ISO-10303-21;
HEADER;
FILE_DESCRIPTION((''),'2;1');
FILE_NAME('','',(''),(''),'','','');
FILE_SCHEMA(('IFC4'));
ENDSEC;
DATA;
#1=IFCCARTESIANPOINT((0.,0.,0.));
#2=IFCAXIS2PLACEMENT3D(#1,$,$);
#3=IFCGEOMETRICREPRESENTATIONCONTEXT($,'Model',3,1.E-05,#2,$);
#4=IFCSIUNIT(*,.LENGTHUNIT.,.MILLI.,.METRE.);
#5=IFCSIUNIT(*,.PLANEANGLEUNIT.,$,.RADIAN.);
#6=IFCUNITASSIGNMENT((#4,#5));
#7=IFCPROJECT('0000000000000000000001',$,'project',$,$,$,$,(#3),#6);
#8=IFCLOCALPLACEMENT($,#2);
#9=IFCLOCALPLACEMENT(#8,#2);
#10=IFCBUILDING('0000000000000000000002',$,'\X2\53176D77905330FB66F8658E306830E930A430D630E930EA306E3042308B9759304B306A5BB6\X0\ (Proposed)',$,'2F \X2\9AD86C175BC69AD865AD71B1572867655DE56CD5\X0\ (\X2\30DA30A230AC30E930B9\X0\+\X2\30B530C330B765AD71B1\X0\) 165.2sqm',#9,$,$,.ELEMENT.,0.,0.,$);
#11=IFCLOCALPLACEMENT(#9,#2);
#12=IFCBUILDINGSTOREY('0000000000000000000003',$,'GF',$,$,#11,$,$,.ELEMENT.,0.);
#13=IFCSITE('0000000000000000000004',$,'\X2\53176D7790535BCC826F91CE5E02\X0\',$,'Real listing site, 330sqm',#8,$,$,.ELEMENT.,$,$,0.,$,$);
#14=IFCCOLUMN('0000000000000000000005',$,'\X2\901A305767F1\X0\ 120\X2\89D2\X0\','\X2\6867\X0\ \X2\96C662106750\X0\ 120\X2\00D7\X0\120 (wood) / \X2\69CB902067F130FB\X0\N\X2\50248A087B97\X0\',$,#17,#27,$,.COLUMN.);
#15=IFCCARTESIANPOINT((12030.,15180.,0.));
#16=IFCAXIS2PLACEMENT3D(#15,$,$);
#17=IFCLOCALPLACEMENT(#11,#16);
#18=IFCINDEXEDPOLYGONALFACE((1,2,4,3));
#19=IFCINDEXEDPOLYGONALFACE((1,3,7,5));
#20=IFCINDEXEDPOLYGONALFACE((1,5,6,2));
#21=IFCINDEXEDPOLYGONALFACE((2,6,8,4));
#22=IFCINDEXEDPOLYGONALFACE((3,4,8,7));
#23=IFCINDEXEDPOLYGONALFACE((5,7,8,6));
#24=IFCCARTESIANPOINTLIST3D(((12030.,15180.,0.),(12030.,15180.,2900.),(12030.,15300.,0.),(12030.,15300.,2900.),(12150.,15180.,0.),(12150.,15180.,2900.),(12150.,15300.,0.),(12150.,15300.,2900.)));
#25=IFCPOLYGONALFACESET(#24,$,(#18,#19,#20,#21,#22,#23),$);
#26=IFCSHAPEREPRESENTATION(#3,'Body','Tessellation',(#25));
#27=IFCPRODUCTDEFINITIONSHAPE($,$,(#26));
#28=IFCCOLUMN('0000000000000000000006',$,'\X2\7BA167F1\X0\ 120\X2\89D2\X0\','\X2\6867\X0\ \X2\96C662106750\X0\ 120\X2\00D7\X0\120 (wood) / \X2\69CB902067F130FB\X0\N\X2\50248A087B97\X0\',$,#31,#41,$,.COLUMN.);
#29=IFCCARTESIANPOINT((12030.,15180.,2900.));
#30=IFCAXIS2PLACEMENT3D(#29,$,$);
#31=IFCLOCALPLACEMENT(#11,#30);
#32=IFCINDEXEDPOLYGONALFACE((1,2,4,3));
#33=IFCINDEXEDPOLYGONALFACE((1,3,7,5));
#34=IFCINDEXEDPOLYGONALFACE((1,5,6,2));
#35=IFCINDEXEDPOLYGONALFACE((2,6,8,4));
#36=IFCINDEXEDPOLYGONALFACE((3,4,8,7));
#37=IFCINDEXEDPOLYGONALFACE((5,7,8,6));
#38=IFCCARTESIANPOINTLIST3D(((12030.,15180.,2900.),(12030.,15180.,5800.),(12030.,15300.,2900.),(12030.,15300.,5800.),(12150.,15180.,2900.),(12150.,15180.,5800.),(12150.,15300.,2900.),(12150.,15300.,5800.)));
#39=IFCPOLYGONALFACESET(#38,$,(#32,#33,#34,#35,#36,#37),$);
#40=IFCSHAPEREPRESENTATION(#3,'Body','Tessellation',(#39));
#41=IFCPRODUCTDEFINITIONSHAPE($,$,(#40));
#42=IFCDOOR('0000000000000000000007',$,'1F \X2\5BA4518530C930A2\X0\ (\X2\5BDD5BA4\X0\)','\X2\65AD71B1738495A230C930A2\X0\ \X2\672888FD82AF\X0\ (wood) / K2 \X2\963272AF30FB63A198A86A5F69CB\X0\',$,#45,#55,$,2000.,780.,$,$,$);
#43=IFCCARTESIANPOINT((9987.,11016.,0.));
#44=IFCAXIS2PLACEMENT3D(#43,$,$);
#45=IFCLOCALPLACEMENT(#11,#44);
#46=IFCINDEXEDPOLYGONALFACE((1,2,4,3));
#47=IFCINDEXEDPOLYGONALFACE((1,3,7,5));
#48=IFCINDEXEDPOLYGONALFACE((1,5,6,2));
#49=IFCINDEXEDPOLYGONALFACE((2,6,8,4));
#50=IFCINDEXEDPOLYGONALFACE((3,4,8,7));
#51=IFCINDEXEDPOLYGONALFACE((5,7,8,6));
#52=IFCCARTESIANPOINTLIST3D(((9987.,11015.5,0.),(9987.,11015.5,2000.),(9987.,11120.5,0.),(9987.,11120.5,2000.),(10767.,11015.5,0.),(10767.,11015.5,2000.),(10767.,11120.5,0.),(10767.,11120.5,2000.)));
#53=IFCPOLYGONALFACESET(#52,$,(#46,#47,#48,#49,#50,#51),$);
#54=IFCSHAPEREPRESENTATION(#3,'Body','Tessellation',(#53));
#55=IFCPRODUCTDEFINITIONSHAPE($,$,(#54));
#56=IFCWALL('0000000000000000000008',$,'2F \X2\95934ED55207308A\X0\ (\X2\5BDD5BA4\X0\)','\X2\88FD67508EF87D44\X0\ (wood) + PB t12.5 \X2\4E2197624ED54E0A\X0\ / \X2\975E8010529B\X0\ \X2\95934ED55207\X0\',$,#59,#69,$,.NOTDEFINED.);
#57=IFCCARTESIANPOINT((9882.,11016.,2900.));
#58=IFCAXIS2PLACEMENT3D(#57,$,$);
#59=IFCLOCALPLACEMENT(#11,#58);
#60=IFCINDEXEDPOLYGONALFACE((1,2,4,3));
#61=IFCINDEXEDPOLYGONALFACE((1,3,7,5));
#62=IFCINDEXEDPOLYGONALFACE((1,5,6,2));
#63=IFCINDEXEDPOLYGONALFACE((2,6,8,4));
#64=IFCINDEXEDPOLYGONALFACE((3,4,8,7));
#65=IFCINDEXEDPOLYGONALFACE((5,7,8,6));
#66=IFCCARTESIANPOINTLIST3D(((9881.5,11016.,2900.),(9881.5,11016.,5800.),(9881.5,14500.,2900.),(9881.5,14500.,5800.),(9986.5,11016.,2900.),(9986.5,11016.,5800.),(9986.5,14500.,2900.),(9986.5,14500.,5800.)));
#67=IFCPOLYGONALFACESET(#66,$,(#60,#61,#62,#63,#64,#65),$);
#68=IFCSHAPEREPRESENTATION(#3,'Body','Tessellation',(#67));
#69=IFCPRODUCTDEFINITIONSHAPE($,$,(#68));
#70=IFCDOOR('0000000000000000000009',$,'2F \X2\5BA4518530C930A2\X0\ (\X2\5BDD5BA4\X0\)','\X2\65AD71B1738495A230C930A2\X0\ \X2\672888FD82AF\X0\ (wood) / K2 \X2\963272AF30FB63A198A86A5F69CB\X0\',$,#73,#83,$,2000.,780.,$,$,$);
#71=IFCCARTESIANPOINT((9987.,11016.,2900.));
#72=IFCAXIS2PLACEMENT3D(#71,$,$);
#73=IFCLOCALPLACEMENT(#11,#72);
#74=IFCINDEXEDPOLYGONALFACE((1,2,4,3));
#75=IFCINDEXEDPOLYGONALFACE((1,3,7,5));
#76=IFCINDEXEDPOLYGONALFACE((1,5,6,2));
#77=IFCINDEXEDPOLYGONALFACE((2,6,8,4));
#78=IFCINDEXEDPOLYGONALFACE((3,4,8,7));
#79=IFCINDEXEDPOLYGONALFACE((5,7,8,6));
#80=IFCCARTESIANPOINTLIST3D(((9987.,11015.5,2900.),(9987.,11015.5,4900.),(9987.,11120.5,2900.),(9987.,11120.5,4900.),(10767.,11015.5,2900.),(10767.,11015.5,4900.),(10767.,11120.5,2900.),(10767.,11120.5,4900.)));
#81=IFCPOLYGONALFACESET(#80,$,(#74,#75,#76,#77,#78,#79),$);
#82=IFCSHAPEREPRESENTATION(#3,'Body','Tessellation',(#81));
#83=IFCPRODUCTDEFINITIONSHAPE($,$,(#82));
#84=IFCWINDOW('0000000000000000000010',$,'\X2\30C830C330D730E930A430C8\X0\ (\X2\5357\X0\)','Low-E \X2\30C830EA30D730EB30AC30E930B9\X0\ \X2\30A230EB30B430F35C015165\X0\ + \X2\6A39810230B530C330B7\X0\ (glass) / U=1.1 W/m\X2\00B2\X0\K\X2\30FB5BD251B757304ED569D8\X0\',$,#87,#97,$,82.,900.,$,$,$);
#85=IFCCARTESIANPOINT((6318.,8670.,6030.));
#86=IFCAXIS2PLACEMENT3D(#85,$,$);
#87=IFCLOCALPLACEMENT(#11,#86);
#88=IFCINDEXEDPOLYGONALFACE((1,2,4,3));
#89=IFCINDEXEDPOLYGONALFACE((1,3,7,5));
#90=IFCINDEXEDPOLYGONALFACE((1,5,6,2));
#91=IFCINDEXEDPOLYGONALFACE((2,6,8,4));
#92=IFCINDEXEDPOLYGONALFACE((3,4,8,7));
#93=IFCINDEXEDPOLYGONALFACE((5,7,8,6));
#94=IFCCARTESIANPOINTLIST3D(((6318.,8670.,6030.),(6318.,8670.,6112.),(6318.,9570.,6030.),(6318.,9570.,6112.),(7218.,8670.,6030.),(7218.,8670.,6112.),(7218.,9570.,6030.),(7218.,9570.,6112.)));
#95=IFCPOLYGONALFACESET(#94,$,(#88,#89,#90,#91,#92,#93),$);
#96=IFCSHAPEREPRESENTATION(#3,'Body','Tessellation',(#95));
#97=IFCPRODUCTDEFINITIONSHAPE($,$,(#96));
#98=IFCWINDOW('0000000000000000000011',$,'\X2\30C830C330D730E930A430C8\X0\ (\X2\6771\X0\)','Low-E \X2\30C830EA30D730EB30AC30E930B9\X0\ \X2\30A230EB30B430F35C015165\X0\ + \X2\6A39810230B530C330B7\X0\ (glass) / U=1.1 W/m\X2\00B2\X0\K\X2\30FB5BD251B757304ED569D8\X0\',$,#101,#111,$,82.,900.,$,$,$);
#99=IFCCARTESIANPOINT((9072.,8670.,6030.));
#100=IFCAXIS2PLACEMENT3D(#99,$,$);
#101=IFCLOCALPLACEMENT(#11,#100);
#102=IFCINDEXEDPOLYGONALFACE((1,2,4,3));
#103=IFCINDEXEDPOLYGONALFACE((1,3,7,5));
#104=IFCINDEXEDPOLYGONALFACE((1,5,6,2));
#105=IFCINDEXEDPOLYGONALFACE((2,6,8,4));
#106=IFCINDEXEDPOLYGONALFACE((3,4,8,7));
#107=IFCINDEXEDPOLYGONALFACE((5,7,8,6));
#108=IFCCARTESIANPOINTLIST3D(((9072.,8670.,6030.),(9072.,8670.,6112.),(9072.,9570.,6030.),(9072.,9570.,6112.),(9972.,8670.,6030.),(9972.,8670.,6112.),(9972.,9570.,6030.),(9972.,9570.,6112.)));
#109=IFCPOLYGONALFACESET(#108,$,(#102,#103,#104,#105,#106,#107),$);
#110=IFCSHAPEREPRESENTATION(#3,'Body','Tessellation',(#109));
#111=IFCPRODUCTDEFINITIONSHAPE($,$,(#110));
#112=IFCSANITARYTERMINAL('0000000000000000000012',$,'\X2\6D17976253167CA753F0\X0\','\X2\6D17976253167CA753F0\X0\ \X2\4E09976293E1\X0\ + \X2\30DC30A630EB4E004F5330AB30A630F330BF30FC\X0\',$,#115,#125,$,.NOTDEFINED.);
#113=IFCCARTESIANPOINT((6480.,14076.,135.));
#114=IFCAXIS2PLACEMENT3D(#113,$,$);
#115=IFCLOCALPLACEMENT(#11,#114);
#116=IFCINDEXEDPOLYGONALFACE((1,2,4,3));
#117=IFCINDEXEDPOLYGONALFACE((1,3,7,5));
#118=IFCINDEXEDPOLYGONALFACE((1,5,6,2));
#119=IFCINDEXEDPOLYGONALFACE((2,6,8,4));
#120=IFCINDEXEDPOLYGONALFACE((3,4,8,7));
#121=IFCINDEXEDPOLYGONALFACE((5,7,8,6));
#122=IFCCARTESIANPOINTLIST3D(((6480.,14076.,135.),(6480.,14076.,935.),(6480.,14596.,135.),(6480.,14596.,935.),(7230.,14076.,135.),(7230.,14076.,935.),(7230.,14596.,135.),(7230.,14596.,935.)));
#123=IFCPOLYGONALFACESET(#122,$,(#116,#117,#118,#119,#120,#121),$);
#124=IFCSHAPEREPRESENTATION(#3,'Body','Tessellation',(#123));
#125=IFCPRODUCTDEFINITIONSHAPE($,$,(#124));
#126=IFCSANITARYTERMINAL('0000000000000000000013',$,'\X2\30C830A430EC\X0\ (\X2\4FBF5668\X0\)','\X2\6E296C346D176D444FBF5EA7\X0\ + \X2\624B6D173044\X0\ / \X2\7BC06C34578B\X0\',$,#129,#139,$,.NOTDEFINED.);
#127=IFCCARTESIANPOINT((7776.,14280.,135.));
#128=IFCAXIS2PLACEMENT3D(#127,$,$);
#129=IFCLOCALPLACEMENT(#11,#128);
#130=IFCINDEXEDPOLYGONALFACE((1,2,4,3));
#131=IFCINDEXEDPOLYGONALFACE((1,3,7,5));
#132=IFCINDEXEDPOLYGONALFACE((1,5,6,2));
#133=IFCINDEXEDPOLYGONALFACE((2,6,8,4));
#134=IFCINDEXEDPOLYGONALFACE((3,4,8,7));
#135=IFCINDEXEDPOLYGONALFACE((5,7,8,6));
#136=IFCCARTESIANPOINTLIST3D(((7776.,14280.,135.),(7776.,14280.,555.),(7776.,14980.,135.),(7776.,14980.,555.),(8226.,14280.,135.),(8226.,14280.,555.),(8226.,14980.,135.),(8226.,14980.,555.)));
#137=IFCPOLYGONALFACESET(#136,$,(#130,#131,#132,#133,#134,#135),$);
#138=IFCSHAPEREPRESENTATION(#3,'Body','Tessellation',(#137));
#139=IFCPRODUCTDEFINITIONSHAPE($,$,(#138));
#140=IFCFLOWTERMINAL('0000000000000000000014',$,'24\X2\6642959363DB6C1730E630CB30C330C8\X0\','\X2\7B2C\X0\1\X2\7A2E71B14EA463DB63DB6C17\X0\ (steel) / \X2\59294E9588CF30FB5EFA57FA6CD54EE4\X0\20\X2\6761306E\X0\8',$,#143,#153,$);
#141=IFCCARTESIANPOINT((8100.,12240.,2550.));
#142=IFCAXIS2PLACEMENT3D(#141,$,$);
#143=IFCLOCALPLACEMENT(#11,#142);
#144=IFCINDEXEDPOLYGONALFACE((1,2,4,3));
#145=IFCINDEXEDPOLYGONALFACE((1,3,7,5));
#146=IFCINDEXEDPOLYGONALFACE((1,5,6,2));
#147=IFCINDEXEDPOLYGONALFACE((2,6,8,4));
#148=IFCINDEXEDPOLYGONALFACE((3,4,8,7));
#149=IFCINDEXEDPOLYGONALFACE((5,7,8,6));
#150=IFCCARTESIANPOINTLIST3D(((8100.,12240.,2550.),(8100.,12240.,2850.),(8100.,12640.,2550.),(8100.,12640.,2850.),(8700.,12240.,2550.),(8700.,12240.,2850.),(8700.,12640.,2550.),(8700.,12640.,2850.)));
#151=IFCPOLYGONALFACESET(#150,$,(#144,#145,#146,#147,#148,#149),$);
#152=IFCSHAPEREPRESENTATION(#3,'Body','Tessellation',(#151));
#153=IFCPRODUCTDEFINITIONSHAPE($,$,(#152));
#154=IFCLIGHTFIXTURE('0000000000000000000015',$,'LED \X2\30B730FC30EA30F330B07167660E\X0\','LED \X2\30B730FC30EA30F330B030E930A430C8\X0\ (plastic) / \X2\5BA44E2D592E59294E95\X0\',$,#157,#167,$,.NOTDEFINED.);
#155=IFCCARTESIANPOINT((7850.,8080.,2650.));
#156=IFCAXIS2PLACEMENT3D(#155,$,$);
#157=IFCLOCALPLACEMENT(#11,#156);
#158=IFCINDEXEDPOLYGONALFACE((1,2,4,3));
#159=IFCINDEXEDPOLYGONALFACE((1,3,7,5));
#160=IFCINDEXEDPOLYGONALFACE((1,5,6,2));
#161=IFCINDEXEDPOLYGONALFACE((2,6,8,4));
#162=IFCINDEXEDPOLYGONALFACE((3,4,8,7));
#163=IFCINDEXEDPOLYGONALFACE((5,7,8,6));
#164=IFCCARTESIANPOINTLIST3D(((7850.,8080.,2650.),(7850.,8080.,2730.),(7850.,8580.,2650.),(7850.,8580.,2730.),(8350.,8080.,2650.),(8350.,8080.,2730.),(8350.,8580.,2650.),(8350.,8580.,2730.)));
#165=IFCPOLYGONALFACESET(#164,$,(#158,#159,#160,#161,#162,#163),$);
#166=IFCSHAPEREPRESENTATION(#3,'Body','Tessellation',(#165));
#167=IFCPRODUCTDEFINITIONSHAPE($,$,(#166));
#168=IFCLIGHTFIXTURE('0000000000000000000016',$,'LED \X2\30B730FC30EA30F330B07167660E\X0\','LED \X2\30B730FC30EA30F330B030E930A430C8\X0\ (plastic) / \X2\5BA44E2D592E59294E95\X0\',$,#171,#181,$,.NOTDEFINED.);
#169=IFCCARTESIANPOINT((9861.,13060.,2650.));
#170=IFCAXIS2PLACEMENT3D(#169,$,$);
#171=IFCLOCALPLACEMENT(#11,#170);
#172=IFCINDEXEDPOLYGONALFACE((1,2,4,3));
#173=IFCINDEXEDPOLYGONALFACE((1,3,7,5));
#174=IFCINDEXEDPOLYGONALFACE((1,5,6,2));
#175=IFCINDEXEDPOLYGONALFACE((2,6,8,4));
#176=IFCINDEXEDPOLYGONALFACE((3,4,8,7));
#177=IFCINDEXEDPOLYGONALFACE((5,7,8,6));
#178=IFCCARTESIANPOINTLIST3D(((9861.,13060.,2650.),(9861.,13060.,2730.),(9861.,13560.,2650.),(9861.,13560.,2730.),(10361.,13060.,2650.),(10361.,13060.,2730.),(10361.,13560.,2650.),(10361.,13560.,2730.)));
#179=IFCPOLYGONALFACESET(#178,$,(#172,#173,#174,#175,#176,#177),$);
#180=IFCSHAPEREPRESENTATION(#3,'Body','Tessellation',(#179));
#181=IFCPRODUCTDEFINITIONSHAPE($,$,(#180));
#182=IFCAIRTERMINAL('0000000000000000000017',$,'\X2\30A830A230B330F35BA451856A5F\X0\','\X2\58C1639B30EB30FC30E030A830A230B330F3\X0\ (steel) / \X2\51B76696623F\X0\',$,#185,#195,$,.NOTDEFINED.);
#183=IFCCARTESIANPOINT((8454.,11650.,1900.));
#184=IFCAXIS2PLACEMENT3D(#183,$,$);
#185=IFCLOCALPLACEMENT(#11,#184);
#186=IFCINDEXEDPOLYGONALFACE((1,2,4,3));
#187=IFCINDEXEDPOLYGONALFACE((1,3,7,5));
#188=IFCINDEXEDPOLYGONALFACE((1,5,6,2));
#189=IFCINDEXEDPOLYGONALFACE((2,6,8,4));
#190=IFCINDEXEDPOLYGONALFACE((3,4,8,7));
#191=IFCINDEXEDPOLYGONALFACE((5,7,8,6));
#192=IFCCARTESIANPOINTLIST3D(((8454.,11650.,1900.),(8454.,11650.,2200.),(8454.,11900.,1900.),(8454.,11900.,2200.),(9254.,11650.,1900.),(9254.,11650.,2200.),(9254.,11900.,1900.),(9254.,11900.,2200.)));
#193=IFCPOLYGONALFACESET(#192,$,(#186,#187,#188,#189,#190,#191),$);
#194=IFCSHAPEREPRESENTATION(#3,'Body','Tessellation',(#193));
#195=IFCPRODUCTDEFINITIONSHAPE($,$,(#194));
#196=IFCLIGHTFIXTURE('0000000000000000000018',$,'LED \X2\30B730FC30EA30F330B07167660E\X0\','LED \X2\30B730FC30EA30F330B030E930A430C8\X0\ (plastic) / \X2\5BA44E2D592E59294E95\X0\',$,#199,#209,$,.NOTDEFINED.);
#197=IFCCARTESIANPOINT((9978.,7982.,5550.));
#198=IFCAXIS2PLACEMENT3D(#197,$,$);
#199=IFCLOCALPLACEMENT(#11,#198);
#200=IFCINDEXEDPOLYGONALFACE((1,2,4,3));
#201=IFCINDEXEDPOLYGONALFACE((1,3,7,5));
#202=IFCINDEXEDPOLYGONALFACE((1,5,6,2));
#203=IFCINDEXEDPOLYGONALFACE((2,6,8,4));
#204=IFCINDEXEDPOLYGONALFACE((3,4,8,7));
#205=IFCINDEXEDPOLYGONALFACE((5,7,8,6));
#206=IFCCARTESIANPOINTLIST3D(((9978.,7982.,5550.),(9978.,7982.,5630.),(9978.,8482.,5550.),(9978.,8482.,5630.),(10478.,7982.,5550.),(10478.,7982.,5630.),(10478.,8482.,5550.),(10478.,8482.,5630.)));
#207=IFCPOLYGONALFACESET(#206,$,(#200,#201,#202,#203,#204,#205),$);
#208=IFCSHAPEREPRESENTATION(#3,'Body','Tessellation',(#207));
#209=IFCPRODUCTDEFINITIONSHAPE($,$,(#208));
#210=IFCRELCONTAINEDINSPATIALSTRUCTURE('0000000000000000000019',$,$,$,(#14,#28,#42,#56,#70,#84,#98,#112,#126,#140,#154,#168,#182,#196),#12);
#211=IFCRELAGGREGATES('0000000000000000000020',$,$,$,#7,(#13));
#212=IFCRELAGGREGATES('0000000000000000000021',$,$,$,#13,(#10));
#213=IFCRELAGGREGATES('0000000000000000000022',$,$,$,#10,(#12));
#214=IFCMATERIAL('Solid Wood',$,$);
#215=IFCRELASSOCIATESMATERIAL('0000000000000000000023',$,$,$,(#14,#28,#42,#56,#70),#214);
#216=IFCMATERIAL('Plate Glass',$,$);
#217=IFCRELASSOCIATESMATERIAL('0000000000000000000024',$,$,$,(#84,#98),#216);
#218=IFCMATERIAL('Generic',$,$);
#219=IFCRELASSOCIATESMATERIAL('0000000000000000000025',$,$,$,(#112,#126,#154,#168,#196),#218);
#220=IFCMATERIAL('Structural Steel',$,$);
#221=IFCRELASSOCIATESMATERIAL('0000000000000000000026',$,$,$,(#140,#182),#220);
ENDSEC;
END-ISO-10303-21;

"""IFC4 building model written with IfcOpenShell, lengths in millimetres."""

from ifc_helpers import new_model, si_unit, frame, frame_2d, origin, place, context, project, spatial, rectangle, extrude, material, element, save


model = new_model("IFC4")

# Units and contexts
model_context = context("Model", 3, precision=1e-05, world=origin())
ifc_project = project(units=[si_unit("LENGTHUNIT", "METRE", prefix="MILLI"), si_unit("PLANEANGLEUNIT", "RADIAN")], contexts=[model_context])

# Site, building, storey
site_placement = place(None, origin())
site = spatial("IfcSite", under=ifc_project, at=site_placement, Name="北海道富良野市", ObjectType="Real listing site, 330sqm", CompositionType="ELEMENT", RefElevation=0.0)
building_placement = place(site_placement, origin())
building = spatial("IfcBuilding", under=site, at=building_placement, Name="北海道・書斎とライブラリのある静かな家 (Proposed)", ObjectType="2F 高気密高断熱在来工法 (ペアガラス+サッシ断熱) 165.2sqm", CompositionType="ELEMENT", ElevationOfRefHeight=0.0, ElevationOfTerrain=0.0)
storey_placement = place(building_placement, origin())
storey = spatial("IfcBuildingStorey", under=building, at=storey_placement, Name="GF", CompositionType="ELEMENT", Elevation=0.0)

# Columns
ifc_material_1 = material(Name="Solid Wood")
column_1_placement = place(storey_placement, frame((12030.0, 15180.0, 0.0)))
element("IfcColumn", 1, at=column_1_placement, inside=storey, material=ifc_material_1, Name="通し柱 120角", Description="桧 集成材 120×120 (wood) / 構造柱・N値計算", PredefinedType="COLUMN", context=model_context, shape_type="SweptSolid", body=[
    extrude(rectangle(XDim=120.0, YDim=120.0, at=frame_2d((60.0, 60.0))), frame((12030.0, 15180.0, 0.0)), (0.0, 0.0, 1.0), 2900.0),
])
column_2_placement = place(storey_placement, frame((12030.0, 15180.0, 2900.0)))
element("IfcColumn", 2, at=column_2_placement, inside=storey, material=ifc_material_1, Name="管柱 120角", Description="桧 集成材 120×120 (wood) / 構造柱・N値計算", PredefinedType="COLUMN", context=model_context, shape_type="SweptSolid", body=[
    extrude(rectangle(XDim=120.0, YDim=120.0, at=frame_2d((60.0, 60.0))), frame((12030.0, 15180.0, 2900.0)), (0.0, 0.0, 1.0), 2900.0),
])

# Door
door_1_placement = place(storey_placement, frame((9987.0, 11016.0, 0.0)))
element("IfcDoor", 3, at=door_1_placement, inside=storey, material=ifc_material_1, Name="1F 室内ドア (寝室)", Description="断熱玄関ドア 木製芯 (wood) / K2 防犯・採風機構", OverallHeight=2000.0, OverallWidth=780.0, context=model_context, shape_type="SweptSolid", body=[
    extrude(rectangle(XDim=780.0, YDim=105.0, at=frame_2d((390.0, 52.0))), frame((9987.0, 11016.0, 0.0)), (0.0, 0.0, 1.0), 2000.0),
])

# Wall
wall_1_placement = place(storey_placement, frame((9882.0, 11016.0, 2900.0)))
element("IfcWall", 4, at=wall_1_placement, inside=storey, material=ifc_material_1, Name="2F 間仕切り (寝室)", Description="製材軸組 (wood) + PB t12.5 両面仕上 / 非耐力 間仕切", PredefinedType="NOTDEFINED", context=model_context, shape_type="SweptSolid", body=[
    extrude(rectangle(XDim=105.0, YDim=3484.0, at=frame_2d((52.0, 1742.0))), frame((9882.0, 11016.0, 2900.0)), (0.0, 0.0, 1.0), 2900.0),
])

# Door
door_2_placement = place(storey_placement, frame((9987.0, 11016.0, 2900.0)))
element("IfcDoor", 5, at=door_2_placement, inside=storey, material=ifc_material_1, Name="2F 室内ドア (寝室)", Description="断熱玄関ドア 木製芯 (wood) / K2 防犯・採風機構", OverallHeight=2000.0, OverallWidth=780.0, context=model_context, shape_type="SweptSolid", body=[
    extrude(rectangle(XDim=780.0, YDim=105.0, at=frame_2d((390.0, 52.0))), frame((9987.0, 11016.0, 2900.0)), (0.0, 0.0, 1.0), 2000.0),
])

# Windows
ifc_material_2 = material(Name="Plate Glass")
window_1_placement = place(storey_placement, frame((6318.0, 8670.0, 6030.0)))
element("IfcWindow", 6, at=window_1_placement, inside=storey, material=ifc_material_2, Name="トップライト (南)", Description="Low-E トリプルガラス アルゴン封入 + 樹脂サッシ (glass) / U=1.1 W/m²K・寒冷地仕様", OverallHeight=82.0, OverallWidth=900.0, context=model_context, shape_type="SweptSolid", body=[
    extrude(rectangle(XDim=900.0, YDim=900.0, at=frame_2d((450.0, 450.0))), frame((6318.0, 8670.0, 6030.0)), (0.0, 0.0, 1.0), 82.0),
])
window_2_placement = place(storey_placement, frame((9072.0, 8670.0, 6030.0)))
element("IfcWindow", 7, at=window_2_placement, inside=storey, material=ifc_material_2, Name="トップライト (東)", Description="Low-E トリプルガラス アルゴン封入 + 樹脂サッシ (glass) / U=1.1 W/m²K・寒冷地仕様", OverallHeight=82.0, OverallWidth=900.0, context=model_context, shape_type="SweptSolid", body=[
    extrude(rectangle(XDim=900.0, YDim=900.0, at=frame_2d((450.0, 450.0))), frame((9072.0, 8670.0, 6030.0)), (0.0, 0.0, 1.0), 82.0),
])

# Sanitary terminals
ifc_material_3 = material(Name="Generic")
sanitary_terminal_1_placement = place(storey_placement, frame((6480.0, 14076.0, 135.0)))
element("IfcSanitaryTerminal", 8, at=sanitary_terminal_1_placement, inside=storey, material=ifc_material_3, Name="洗面化粧台", Description="洗面化粧台 三面鏡 + ボウル一体カウンター", PredefinedType="NOTDEFINED", context=model_context, shape_type="SweptSolid", body=[
    extrude(rectangle(XDim=750.0, YDim=520.0, at=frame_2d((375.0, 260.0))), frame((6480.0, 14076.0, 135.0)), (0.0, 0.0, 1.0), 800.0),
])
sanitary_terminal_2_placement = place(storey_placement, frame((7776.0, 14280.0, 135.0)))
element("IfcSanitaryTerminal", 9, at=sanitary_terminal_2_placement, inside=storey, material=ifc_material_3, Name="トイレ (便器)", Description="温水洗浄便座 + 手洗い / 節水型", PredefinedType="NOTDEFINED", context=model_context, shape_type="SweptSolid", body=[
    extrude(rectangle(XDim=450.0, YDim=700.0, at=frame_2d((225.0, 350.0))), frame((7776.0, 14280.0, 135.0)), (0.0, 0.0, 1.0), 420.0),
])

# Flow terminal
ifc_material_4 = material(Name="Structural Steel")
flow_terminal_placement = place(storey_placement, frame((8100.0, 12240.0, 2550.0)))
element("IfcFlowTerminal", 10, at=flow_terminal_placement, inside=storey, material=ifc_material_4, Name="24時間換気ユニット", Description="第1種熱交換換気 (steel) / 天井裏・建基法令20条の8", context=model_context, shape_type="SweptSolid", body=[
    extrude(rectangle(XDim=600.0, YDim=400.0, at=frame_2d((300.0, 200.0))), frame((8100.0, 12240.0, 2550.0)), (0.0, 0.0, 1.0), 300.0),
])

# Light fixtures
light_fixture_1_placement = place(storey_placement, frame((7850.0, 8080.0, 2650.0)))
element("IfcLightFixture", 11, at=light_fixture_1_placement, inside=storey, material=ifc_material_3, Name="LED シーリング照明", Description="LED シーリングライト (plastic) / 室中央天井", PredefinedType="NOTDEFINED", context=model_context, shape_type="SweptSolid", body=[
    extrude(rectangle(XDim=500.0, YDim=500.0, at=frame_2d((250.0, 250.0))), frame((7850.0, 8080.0, 2650.0)), (0.0, 0.0, 1.0), 80.0),
])
light_fixture_2_placement = place(storey_placement, frame((9861.0, 13060.0, 2650.0)))
element("IfcLightFixture", 12, at=light_fixture_2_placement, inside=storey, material=ifc_material_3, Name="LED シーリング照明", Description="LED シーリングライト (plastic) / 室中央天井", PredefinedType="NOTDEFINED", context=model_context, shape_type="SweptSolid", body=[
    extrude(rectangle(XDim=500.0, YDim=500.0, at=frame_2d((250.0, 250.0))), frame((9861.0, 13060.0, 2650.0)), (0.0, 0.0, 1.0), 80.0),
])

# Air terminal
air_terminal_placement = place(storey_placement, frame((8454.0, 11650.0, 1900.0)))
element("IfcAirTerminal", 13, at=air_terminal_placement, inside=storey, material=ifc_material_4, Name="エアコン室内機", Description="壁掛ルームエアコン (steel) / 冷暖房", PredefinedType="NOTDEFINED", context=model_context, shape_type="SweptSolid", body=[
    extrude(rectangle(XDim=800.0, YDim=250.0, at=frame_2d((400.0, 125.0))), frame((8454.0, 11650.0, 1900.0)), (0.0, 0.0, 1.0), 300.0),
])

# Light fixture
light_fixture_3_placement = place(storey_placement, frame((9978.0, 7982.0, 5550.0)))
element("IfcLightFixture", 14, at=light_fixture_3_placement, inside=storey, material=ifc_material_3, Name="LED シーリング照明", Description="LED シーリングライト (plastic) / 室中央天井", PredefinedType="NOTDEFINED", context=model_context, shape_type="SweptSolid", body=[
    extrude(rectangle(XDim=500.0, YDim=500.0, at=frame_2d((250.0, 250.0))), frame((9978.0, 7982.0, 5550.0)), (0.0, 0.0, 1.0), 80.0),
])

save(model, "model.ifc")
